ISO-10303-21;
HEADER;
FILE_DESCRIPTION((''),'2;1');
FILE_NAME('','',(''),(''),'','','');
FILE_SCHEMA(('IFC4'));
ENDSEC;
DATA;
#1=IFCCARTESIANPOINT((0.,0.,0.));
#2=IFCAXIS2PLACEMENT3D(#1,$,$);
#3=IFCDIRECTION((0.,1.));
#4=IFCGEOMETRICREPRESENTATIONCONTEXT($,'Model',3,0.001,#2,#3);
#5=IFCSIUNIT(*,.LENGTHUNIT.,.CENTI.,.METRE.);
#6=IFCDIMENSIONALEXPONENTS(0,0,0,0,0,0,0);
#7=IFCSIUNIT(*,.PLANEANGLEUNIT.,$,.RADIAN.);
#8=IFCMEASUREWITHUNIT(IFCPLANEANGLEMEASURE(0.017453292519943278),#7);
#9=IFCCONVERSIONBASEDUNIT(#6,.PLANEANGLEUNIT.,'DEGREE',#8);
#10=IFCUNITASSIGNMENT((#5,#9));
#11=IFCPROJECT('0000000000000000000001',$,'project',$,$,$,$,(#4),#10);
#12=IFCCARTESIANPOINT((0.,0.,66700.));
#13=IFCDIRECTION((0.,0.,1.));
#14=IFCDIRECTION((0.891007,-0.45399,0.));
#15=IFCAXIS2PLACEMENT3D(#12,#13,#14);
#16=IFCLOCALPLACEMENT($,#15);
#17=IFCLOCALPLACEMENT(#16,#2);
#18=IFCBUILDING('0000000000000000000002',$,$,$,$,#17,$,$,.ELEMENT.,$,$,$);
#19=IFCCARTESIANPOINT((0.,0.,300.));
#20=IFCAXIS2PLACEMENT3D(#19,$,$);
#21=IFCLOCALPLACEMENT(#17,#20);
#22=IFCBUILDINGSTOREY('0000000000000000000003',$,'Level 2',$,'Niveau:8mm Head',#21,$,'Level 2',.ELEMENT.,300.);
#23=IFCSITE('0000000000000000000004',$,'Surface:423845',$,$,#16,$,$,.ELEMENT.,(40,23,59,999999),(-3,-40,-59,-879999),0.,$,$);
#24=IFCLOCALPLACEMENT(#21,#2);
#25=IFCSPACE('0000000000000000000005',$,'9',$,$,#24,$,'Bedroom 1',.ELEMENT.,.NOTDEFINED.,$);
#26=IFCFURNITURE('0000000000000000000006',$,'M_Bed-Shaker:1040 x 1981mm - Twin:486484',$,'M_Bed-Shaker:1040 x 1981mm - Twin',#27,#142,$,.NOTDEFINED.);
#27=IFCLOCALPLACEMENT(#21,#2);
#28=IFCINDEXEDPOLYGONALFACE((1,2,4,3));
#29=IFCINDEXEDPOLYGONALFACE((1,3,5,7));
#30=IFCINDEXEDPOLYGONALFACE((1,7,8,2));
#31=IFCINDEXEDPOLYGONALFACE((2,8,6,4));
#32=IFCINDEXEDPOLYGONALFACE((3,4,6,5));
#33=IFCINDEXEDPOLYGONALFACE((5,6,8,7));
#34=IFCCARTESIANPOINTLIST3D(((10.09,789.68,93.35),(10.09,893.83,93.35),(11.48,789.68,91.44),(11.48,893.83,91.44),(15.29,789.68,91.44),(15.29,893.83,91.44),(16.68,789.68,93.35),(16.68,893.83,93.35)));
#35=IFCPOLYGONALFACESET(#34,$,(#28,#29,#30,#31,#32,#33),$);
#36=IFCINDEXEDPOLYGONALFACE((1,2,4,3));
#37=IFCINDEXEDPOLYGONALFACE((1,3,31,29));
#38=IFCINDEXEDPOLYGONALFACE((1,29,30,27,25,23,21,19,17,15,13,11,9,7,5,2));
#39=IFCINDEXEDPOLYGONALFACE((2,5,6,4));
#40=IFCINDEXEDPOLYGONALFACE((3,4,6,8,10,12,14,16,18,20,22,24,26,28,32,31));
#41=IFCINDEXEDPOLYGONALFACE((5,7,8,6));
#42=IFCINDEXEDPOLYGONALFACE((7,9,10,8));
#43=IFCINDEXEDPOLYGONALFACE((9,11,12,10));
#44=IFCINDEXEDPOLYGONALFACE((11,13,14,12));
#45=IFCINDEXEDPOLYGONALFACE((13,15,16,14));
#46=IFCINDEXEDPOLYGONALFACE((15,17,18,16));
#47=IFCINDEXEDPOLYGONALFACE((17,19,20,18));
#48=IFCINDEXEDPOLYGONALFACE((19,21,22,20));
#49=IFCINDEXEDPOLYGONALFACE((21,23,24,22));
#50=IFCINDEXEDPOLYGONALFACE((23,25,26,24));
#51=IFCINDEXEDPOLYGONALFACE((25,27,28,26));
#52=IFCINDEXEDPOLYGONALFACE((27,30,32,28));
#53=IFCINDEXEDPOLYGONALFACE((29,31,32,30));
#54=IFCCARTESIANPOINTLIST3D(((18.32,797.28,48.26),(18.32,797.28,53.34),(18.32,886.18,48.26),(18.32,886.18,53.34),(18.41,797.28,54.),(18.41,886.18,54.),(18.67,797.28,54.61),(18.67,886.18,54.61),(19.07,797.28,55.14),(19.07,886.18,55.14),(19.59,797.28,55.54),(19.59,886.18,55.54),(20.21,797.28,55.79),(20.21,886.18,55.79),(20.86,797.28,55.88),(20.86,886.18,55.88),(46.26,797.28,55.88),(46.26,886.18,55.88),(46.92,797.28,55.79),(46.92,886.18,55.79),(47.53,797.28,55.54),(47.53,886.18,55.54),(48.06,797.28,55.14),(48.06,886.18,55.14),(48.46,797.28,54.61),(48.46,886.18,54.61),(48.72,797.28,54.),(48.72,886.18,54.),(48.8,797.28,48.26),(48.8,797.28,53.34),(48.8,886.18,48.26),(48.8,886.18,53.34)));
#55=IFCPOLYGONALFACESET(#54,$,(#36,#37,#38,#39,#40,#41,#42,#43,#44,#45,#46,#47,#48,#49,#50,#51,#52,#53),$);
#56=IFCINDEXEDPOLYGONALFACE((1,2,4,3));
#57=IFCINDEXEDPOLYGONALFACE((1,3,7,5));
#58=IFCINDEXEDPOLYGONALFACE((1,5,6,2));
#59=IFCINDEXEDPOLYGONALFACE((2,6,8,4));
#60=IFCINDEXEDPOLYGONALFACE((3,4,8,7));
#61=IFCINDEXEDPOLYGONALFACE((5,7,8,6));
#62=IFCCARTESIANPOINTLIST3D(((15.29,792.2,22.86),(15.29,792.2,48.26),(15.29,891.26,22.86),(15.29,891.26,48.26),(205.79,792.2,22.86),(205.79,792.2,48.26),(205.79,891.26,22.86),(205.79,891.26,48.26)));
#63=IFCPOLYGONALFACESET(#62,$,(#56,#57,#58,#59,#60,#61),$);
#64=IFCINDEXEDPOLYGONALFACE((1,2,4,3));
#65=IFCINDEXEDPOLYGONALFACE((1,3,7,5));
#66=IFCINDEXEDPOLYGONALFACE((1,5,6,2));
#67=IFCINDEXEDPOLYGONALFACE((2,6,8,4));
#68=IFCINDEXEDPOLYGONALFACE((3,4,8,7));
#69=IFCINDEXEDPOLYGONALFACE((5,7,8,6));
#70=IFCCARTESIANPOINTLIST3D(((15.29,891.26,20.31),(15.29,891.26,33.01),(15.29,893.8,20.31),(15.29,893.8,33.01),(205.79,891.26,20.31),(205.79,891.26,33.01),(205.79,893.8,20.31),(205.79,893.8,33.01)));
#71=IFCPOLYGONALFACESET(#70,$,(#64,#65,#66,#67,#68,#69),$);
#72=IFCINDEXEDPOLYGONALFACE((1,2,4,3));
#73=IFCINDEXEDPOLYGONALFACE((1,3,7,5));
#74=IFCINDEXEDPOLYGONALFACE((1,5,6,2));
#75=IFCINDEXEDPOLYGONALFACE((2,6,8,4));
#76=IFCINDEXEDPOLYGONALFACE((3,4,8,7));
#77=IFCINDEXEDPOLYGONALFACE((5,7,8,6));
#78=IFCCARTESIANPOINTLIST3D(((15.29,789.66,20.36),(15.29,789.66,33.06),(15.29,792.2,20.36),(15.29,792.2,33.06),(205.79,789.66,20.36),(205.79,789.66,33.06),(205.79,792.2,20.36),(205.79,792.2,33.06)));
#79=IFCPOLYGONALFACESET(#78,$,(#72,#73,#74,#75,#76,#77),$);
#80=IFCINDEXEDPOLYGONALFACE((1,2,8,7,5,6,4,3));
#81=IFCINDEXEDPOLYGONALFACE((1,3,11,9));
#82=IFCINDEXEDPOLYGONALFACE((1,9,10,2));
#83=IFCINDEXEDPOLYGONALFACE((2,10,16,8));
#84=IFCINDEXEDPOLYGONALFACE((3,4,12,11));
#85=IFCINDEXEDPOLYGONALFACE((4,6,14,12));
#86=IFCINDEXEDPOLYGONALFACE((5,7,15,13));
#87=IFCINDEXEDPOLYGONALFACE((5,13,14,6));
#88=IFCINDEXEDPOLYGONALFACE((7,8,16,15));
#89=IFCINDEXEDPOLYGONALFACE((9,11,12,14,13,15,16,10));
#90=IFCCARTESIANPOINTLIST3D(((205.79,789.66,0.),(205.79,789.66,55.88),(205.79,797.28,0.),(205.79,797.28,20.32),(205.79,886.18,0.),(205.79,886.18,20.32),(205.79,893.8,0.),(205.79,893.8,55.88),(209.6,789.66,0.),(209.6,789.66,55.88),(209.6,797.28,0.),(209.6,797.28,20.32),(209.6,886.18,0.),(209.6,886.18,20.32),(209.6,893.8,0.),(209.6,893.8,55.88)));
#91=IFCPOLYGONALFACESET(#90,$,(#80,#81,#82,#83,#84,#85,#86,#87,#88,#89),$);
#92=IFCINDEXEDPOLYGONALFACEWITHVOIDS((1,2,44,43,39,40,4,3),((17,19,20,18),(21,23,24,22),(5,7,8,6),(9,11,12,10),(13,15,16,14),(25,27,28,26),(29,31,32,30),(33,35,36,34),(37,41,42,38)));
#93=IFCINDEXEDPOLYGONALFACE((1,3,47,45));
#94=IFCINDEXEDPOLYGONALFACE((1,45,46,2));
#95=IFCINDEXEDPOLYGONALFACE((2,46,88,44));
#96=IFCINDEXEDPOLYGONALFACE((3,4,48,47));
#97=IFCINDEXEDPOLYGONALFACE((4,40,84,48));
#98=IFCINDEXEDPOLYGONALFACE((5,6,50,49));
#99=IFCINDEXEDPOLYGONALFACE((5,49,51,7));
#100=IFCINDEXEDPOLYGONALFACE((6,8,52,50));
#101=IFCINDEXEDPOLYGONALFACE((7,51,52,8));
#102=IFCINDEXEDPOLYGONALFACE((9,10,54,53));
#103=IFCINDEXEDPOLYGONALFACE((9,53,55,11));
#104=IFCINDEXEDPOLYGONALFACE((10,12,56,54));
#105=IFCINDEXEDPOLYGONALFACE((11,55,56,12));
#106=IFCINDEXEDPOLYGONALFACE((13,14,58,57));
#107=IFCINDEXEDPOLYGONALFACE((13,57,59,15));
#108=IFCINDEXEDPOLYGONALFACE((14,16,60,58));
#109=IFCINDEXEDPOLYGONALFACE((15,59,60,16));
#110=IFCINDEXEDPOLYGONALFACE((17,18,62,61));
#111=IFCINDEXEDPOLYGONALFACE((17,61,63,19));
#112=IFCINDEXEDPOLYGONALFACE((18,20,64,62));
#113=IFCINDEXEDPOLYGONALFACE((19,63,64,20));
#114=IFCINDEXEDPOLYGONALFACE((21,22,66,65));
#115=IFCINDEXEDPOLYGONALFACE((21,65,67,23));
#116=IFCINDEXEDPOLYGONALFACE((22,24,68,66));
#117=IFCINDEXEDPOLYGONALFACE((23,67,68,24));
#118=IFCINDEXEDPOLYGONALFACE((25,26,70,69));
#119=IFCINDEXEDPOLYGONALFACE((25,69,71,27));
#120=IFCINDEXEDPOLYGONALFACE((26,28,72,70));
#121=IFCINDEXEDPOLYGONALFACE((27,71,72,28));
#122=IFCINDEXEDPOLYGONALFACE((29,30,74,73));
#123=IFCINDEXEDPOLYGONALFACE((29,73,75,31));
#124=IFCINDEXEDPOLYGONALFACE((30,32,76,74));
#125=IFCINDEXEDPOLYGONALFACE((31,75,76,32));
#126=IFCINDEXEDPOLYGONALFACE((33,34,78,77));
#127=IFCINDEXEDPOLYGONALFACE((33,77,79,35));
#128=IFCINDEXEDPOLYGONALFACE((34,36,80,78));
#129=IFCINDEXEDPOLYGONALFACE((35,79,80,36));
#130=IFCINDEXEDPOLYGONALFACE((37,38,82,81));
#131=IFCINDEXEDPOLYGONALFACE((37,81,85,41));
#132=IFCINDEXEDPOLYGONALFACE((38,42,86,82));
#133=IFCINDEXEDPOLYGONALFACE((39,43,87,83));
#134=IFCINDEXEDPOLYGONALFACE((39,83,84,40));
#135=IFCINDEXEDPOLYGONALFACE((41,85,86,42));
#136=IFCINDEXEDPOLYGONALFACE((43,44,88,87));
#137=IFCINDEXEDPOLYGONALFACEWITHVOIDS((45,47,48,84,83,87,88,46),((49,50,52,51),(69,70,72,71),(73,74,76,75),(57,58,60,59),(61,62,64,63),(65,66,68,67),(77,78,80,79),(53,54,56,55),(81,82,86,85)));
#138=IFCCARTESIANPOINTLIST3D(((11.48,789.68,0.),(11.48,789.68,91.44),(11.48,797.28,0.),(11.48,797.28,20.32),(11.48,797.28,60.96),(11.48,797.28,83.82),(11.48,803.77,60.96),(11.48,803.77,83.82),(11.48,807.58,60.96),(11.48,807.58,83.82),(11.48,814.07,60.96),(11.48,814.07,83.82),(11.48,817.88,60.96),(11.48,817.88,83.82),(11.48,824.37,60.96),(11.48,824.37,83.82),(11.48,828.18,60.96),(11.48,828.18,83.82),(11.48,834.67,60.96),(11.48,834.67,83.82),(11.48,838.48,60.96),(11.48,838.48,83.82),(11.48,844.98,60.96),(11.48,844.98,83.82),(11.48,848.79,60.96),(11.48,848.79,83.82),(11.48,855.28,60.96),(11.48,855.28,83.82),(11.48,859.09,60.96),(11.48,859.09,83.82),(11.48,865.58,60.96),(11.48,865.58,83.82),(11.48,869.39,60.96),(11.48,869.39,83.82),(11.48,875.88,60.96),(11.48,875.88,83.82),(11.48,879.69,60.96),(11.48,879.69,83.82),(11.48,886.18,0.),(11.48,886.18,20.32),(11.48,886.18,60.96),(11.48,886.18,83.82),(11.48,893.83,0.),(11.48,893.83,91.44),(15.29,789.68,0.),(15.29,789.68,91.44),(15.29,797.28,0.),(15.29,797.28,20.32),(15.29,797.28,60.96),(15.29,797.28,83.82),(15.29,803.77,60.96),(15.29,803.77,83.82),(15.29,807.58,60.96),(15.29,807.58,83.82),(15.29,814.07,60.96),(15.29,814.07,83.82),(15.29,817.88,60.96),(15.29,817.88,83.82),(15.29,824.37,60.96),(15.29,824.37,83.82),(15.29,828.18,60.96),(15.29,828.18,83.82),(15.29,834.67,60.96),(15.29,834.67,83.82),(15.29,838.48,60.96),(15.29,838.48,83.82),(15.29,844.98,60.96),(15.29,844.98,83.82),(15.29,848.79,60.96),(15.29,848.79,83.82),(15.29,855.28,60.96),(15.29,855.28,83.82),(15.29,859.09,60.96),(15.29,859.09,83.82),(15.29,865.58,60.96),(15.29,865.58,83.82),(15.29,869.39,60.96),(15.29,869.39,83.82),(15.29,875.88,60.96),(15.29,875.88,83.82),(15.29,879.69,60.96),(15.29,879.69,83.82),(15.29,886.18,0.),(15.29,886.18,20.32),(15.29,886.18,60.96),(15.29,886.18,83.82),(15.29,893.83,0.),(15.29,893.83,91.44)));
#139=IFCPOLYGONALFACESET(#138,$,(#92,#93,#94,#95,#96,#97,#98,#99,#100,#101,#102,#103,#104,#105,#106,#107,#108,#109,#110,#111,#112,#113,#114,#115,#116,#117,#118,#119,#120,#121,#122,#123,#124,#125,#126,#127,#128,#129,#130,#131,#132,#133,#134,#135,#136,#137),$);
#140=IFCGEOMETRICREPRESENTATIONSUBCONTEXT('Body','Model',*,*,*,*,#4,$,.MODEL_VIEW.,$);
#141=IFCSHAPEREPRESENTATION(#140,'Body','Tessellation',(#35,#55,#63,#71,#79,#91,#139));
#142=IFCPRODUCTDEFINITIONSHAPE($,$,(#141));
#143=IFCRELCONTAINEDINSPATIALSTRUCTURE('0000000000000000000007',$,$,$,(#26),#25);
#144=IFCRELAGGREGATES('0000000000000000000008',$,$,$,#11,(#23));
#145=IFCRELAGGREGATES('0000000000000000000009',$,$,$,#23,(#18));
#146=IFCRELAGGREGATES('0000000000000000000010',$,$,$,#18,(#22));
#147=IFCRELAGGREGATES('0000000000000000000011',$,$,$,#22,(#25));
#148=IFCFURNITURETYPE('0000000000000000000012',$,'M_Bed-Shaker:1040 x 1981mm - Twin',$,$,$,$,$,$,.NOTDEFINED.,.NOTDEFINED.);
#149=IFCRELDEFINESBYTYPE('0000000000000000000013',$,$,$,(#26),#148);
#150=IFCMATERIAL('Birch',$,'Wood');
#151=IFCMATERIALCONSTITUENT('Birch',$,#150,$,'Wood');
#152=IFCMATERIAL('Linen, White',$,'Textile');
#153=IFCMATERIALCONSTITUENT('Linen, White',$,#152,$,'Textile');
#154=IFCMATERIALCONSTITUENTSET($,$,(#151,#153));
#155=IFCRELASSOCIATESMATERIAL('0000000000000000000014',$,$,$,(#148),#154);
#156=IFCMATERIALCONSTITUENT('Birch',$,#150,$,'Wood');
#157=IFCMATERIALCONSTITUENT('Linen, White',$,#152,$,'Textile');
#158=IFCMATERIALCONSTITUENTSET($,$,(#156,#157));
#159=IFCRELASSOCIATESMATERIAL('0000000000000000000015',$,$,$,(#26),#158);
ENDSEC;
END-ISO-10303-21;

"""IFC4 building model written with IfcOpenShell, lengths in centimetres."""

from ifc_helpers import new_model, entity, si_unit, converted_unit, direction, frame, frame_2d, origin, origin_2d_with_axis, place, context, subcontext, project, spatial, polyline, circle_curve, parameter, trimmed, segment, composite_curve, rectangle, outline, extrude, source, transform, mapped, material, constituent, constituent_set, type_object, type_shapes, element, save


model = new_model("IFC4")

# Units and contexts
model_context = context("Model", 3, precision=0.001, world=origin(), true_north=direction((0.0, 1.0)))
body_context = subcontext(model_context, "Body", "Model", "MODEL_VIEW")
ifc_project = project(units=[si_unit("LENGTHUNIT", "METRE", prefix="CENTI"), converted_unit("PLANEANGLEUNIT", "DEGREE", entity("IfcPlaneAngleMeasure", 0.017453292519943278), si_unit("PLANEANGLEUNIT", "RADIAN"), dimensions=[0, 0, 0, 0, 0, 0, 0])], contexts=[model_context])

# Site, building, storey
site_placement = place(None, frame((0.0, 0.0, 66700.0), z_axis=(0.0, 0.0, 1.0), x_axis=(0.891007, -0.45399, 0.0)))
site = spatial("IfcSite", under=ifc_project, at=site_placement, Name="Surface:423845", CompositionType="ELEMENT", RefLatitude=(40, 23, 59, 999999), RefLongitude=(-3, -40, -59, -879999), RefElevation=0.0)
building_placement = place(site_placement, origin())
building = spatial("IfcBuilding", under=site, at=building_placement, CompositionType="ELEMENT")
storey_placement = place(building_placement, frame((0.0, 0.0, 300.0)))
storey = spatial("IfcBuildingStorey", under=building, at=storey_placement, Name="Level 2", ObjectType="Niveau:8mm Head", LongName="Level 2", CompositionType="ELEMENT", Elevation=300.0)

# Shared definitions
space_placement = place(storey_placement, origin())
space = spatial("IfcSpace", under=storey, at=space_placement, Name="9", LongName="Bedroom 1", CompositionType="ELEMENT", PredefinedType="NOTDEFINED")

# Furniture
ifc_material_1 = material(Name="Birch", Category="Wood")
ifc_material_2 = material(Name="Linen, White", Category="Textile")
ifc_constituent_1 = constituent(ifc_material_1, Name="Birch", Category="Wood")
ifc_constituent_2 = constituent(ifc_material_2, Name="Linen, White", Category="Textile")
ifc_constituent_set_1 = constituent_set(constituents=[ifc_constituent_1, ifc_constituent_2])
furniture_type = type_object("IfcFurnitureType", Name="M_Bed-Shaker:1040 x 1981mm - Twin", AssemblyPlace="NOTDEFINED", PredefinedType="NOTDEFINED", material=ifc_constituent_set_1)
shared_shape_1 = source(origin(), body_context, "Body", "SweptSolid", [
    extrude(outline(polyline([(-1.91, -0.95), (1.9, -0.95), (3.29, 0.95), (-3.29, 0.95), (-1.91, -0.95)])), frame((-53.95, -1.9, 92.39), z_axis=(1.0, 0.0, 0.0), x_axis=(0.0, 1.0, 0.0)), (0.0, 0.0, 1.0), 104.15),
    extrude(outline(composite_curve([segment(polyline([(-15.24, -4.23), (15.24, -4.23)]), True, "CONTINUOUS"), segment(polyline([(15.24, -4.23), (15.24, 0.85)]), True, "CONTINUOUS"), segment(trimmed(circle_curve(frame_2d((12.7, 0.85), x_axis=(-1.0, 0.0)), 2.54), [parameter(180.0)], [parameter(270.0)], True, "PARAMETER"), True, "CONTINUOUS"), segment(polyline([(12.7, 3.39), (-12.7, 3.39)]), True, "CONTINUOUS"), segment(trimmed(circle_curve(frame_2d((-12.7, 0.85), x_axis=(-1.0, 0.0)), 2.54), [parameter(270.0)], [parameter(0.0)], True, "PARAMETER"), True, "CONTINUOUS"), segment(polyline([(-15.24, 0.85), (-15.24, -4.23)]), True, "CONTINUOUS")], self_intersect=False)), frame((-46.36, -22.08, 52.49), z_axis=(1.0, 0.0, 0.0), x_axis=(0.0, 1.0, 0.0)), (0.0, 0.0, 1.0), 88.9),
    extrude(rectangle(XDim=99.06, YDim=190.5, at=origin_2d_with_axis()), frame((-1.9, -99.06, 22.86), z_axis=(0.0, 0.0, 1.0), x_axis=(-1.0, 0.0, 0.0)), (0.0, 0.0, 1.0), 25.4),
    extrude(rectangle(XDim=2.54, YDim=190.5, at=frame_2d((0.0, 0.0), x_axis=(1.0, 0.0))), frame((48.89, -99.06, 20.31)), (0.0, 0.0, 1.0), 12.7),
    extrude(rectangle(XDim=2.54, YDim=190.5, at=frame_2d((0.0, 0.0), x_axis=(1.0, 0.0))), frame((-52.71, -99.06, 20.36)), (0.0, 0.0, 1.0), 12.7),
    extrude(outline(polyline([(44.45, -19.05), (52.07, -19.05), (52.07, 36.83), (-52.07, 36.83), (-52.07, -19.05), (-44.45, -19.05), (-44.45, 1.27), (44.45, 1.27), (44.45, -19.05)])), frame((-1.91, -198.12, 19.05), z_axis=(0.0, 1.0, 0.0), x_axis=(-1.0, 0.0, 0.0)), (0.0, 0.0, 1.0), 3.81),
    extrude(outline(polyline([(-63.5, -52.08), (27.94, -52.08), (27.94, -44.44), (7.62, -44.44), (7.62, 44.46), (27.94, 44.46), (27.94, 52.06), (-63.5, 52.06), (-63.5, -52.08)]), holes=[polyline([(-55.88, 37.97), (-55.88, 44.46), (-33.02, 44.46), (-33.02, 37.97), (-55.88, 37.97)]), polyline([(-55.88, 27.67), (-55.88, 34.16), (-33.02, 34.16), (-33.02, 27.67), (-55.88, 27.67)]), polyline([(-55.88, 17.37), (-55.88, 23.86), (-33.02, 23.86), (-33.02, 17.37), (-55.88, 17.37)]), polyline([(-55.88, 7.07), (-55.88, 13.56), (-33.02, 13.56), (-33.02, 7.07), (-55.88, 7.07)]), polyline([(-55.88, -13.53), (-55.88, -7.04), (-33.02, -7.04), (-33.02, -13.53), (-55.88, -13.53)]), polyline([(-55.88, -23.84), (-55.88, -17.34), (-33.02, -17.34), (-33.02, -23.84), (-55.88, -23.84)]), polyline([(-55.88, -34.14), (-55.88, -27.65), (-33.02, -27.65), (-33.02, -34.14), (-55.88, -34.14)]), polyline([(-55.88, -44.44), (-55.88, -37.95), (-33.02, -37.95), (-33.02, -44.44), (-55.88, -44.44)]), polyline([(-55.88, -3.23), (-55.88, 3.26), (-33.02, 3.26), (-33.02, -3.23), (-55.88, -3.23)])]), frame((-1.89, -3.81, 27.94), z_axis=(0.0, 1.0, 0.0), x_axis=(0.0, 0.0, -1.0)), (0.0, 0.0, 1.0), 3.81),
])
type_shapes(furniture_type, [shared_shape_1])
ifc_constituent_3 = constituent(ifc_material_1, Name="Birch", Category="Wood")
ifc_constituent_4 = constituent(ifc_material_2, Name="Linen, White", Category="Textile")
ifc_constituent_set_2 = constituent_set(constituents=[ifc_constituent_3, ifc_constituent_4])
furniture_1_placement = place(space_placement, frame((11.48, 843.63, 0.0), z_axis=(0.0, 0.0, 1.0), x_axis=(0.0, 1.0, 0.0)))
element("IfcFurniture", 1, at=furniture_1_placement, inside=space, type_object=furniture_type, material=ifc_constituent_set_2, Name="M_Bed-Shaker:1040 x 1981mm - Twin:486484", ObjectType="M_Bed-Shaker:1040 x 1981mm - Twin", PredefinedType="NOTDEFINED", context=body_context, shape_type="MappedRepresentation", body=[
    mapped(shared_shape_1, transform((0.0, 0.0, 0.0), scale=1.0)),
])

save(model, "model.ifc")
